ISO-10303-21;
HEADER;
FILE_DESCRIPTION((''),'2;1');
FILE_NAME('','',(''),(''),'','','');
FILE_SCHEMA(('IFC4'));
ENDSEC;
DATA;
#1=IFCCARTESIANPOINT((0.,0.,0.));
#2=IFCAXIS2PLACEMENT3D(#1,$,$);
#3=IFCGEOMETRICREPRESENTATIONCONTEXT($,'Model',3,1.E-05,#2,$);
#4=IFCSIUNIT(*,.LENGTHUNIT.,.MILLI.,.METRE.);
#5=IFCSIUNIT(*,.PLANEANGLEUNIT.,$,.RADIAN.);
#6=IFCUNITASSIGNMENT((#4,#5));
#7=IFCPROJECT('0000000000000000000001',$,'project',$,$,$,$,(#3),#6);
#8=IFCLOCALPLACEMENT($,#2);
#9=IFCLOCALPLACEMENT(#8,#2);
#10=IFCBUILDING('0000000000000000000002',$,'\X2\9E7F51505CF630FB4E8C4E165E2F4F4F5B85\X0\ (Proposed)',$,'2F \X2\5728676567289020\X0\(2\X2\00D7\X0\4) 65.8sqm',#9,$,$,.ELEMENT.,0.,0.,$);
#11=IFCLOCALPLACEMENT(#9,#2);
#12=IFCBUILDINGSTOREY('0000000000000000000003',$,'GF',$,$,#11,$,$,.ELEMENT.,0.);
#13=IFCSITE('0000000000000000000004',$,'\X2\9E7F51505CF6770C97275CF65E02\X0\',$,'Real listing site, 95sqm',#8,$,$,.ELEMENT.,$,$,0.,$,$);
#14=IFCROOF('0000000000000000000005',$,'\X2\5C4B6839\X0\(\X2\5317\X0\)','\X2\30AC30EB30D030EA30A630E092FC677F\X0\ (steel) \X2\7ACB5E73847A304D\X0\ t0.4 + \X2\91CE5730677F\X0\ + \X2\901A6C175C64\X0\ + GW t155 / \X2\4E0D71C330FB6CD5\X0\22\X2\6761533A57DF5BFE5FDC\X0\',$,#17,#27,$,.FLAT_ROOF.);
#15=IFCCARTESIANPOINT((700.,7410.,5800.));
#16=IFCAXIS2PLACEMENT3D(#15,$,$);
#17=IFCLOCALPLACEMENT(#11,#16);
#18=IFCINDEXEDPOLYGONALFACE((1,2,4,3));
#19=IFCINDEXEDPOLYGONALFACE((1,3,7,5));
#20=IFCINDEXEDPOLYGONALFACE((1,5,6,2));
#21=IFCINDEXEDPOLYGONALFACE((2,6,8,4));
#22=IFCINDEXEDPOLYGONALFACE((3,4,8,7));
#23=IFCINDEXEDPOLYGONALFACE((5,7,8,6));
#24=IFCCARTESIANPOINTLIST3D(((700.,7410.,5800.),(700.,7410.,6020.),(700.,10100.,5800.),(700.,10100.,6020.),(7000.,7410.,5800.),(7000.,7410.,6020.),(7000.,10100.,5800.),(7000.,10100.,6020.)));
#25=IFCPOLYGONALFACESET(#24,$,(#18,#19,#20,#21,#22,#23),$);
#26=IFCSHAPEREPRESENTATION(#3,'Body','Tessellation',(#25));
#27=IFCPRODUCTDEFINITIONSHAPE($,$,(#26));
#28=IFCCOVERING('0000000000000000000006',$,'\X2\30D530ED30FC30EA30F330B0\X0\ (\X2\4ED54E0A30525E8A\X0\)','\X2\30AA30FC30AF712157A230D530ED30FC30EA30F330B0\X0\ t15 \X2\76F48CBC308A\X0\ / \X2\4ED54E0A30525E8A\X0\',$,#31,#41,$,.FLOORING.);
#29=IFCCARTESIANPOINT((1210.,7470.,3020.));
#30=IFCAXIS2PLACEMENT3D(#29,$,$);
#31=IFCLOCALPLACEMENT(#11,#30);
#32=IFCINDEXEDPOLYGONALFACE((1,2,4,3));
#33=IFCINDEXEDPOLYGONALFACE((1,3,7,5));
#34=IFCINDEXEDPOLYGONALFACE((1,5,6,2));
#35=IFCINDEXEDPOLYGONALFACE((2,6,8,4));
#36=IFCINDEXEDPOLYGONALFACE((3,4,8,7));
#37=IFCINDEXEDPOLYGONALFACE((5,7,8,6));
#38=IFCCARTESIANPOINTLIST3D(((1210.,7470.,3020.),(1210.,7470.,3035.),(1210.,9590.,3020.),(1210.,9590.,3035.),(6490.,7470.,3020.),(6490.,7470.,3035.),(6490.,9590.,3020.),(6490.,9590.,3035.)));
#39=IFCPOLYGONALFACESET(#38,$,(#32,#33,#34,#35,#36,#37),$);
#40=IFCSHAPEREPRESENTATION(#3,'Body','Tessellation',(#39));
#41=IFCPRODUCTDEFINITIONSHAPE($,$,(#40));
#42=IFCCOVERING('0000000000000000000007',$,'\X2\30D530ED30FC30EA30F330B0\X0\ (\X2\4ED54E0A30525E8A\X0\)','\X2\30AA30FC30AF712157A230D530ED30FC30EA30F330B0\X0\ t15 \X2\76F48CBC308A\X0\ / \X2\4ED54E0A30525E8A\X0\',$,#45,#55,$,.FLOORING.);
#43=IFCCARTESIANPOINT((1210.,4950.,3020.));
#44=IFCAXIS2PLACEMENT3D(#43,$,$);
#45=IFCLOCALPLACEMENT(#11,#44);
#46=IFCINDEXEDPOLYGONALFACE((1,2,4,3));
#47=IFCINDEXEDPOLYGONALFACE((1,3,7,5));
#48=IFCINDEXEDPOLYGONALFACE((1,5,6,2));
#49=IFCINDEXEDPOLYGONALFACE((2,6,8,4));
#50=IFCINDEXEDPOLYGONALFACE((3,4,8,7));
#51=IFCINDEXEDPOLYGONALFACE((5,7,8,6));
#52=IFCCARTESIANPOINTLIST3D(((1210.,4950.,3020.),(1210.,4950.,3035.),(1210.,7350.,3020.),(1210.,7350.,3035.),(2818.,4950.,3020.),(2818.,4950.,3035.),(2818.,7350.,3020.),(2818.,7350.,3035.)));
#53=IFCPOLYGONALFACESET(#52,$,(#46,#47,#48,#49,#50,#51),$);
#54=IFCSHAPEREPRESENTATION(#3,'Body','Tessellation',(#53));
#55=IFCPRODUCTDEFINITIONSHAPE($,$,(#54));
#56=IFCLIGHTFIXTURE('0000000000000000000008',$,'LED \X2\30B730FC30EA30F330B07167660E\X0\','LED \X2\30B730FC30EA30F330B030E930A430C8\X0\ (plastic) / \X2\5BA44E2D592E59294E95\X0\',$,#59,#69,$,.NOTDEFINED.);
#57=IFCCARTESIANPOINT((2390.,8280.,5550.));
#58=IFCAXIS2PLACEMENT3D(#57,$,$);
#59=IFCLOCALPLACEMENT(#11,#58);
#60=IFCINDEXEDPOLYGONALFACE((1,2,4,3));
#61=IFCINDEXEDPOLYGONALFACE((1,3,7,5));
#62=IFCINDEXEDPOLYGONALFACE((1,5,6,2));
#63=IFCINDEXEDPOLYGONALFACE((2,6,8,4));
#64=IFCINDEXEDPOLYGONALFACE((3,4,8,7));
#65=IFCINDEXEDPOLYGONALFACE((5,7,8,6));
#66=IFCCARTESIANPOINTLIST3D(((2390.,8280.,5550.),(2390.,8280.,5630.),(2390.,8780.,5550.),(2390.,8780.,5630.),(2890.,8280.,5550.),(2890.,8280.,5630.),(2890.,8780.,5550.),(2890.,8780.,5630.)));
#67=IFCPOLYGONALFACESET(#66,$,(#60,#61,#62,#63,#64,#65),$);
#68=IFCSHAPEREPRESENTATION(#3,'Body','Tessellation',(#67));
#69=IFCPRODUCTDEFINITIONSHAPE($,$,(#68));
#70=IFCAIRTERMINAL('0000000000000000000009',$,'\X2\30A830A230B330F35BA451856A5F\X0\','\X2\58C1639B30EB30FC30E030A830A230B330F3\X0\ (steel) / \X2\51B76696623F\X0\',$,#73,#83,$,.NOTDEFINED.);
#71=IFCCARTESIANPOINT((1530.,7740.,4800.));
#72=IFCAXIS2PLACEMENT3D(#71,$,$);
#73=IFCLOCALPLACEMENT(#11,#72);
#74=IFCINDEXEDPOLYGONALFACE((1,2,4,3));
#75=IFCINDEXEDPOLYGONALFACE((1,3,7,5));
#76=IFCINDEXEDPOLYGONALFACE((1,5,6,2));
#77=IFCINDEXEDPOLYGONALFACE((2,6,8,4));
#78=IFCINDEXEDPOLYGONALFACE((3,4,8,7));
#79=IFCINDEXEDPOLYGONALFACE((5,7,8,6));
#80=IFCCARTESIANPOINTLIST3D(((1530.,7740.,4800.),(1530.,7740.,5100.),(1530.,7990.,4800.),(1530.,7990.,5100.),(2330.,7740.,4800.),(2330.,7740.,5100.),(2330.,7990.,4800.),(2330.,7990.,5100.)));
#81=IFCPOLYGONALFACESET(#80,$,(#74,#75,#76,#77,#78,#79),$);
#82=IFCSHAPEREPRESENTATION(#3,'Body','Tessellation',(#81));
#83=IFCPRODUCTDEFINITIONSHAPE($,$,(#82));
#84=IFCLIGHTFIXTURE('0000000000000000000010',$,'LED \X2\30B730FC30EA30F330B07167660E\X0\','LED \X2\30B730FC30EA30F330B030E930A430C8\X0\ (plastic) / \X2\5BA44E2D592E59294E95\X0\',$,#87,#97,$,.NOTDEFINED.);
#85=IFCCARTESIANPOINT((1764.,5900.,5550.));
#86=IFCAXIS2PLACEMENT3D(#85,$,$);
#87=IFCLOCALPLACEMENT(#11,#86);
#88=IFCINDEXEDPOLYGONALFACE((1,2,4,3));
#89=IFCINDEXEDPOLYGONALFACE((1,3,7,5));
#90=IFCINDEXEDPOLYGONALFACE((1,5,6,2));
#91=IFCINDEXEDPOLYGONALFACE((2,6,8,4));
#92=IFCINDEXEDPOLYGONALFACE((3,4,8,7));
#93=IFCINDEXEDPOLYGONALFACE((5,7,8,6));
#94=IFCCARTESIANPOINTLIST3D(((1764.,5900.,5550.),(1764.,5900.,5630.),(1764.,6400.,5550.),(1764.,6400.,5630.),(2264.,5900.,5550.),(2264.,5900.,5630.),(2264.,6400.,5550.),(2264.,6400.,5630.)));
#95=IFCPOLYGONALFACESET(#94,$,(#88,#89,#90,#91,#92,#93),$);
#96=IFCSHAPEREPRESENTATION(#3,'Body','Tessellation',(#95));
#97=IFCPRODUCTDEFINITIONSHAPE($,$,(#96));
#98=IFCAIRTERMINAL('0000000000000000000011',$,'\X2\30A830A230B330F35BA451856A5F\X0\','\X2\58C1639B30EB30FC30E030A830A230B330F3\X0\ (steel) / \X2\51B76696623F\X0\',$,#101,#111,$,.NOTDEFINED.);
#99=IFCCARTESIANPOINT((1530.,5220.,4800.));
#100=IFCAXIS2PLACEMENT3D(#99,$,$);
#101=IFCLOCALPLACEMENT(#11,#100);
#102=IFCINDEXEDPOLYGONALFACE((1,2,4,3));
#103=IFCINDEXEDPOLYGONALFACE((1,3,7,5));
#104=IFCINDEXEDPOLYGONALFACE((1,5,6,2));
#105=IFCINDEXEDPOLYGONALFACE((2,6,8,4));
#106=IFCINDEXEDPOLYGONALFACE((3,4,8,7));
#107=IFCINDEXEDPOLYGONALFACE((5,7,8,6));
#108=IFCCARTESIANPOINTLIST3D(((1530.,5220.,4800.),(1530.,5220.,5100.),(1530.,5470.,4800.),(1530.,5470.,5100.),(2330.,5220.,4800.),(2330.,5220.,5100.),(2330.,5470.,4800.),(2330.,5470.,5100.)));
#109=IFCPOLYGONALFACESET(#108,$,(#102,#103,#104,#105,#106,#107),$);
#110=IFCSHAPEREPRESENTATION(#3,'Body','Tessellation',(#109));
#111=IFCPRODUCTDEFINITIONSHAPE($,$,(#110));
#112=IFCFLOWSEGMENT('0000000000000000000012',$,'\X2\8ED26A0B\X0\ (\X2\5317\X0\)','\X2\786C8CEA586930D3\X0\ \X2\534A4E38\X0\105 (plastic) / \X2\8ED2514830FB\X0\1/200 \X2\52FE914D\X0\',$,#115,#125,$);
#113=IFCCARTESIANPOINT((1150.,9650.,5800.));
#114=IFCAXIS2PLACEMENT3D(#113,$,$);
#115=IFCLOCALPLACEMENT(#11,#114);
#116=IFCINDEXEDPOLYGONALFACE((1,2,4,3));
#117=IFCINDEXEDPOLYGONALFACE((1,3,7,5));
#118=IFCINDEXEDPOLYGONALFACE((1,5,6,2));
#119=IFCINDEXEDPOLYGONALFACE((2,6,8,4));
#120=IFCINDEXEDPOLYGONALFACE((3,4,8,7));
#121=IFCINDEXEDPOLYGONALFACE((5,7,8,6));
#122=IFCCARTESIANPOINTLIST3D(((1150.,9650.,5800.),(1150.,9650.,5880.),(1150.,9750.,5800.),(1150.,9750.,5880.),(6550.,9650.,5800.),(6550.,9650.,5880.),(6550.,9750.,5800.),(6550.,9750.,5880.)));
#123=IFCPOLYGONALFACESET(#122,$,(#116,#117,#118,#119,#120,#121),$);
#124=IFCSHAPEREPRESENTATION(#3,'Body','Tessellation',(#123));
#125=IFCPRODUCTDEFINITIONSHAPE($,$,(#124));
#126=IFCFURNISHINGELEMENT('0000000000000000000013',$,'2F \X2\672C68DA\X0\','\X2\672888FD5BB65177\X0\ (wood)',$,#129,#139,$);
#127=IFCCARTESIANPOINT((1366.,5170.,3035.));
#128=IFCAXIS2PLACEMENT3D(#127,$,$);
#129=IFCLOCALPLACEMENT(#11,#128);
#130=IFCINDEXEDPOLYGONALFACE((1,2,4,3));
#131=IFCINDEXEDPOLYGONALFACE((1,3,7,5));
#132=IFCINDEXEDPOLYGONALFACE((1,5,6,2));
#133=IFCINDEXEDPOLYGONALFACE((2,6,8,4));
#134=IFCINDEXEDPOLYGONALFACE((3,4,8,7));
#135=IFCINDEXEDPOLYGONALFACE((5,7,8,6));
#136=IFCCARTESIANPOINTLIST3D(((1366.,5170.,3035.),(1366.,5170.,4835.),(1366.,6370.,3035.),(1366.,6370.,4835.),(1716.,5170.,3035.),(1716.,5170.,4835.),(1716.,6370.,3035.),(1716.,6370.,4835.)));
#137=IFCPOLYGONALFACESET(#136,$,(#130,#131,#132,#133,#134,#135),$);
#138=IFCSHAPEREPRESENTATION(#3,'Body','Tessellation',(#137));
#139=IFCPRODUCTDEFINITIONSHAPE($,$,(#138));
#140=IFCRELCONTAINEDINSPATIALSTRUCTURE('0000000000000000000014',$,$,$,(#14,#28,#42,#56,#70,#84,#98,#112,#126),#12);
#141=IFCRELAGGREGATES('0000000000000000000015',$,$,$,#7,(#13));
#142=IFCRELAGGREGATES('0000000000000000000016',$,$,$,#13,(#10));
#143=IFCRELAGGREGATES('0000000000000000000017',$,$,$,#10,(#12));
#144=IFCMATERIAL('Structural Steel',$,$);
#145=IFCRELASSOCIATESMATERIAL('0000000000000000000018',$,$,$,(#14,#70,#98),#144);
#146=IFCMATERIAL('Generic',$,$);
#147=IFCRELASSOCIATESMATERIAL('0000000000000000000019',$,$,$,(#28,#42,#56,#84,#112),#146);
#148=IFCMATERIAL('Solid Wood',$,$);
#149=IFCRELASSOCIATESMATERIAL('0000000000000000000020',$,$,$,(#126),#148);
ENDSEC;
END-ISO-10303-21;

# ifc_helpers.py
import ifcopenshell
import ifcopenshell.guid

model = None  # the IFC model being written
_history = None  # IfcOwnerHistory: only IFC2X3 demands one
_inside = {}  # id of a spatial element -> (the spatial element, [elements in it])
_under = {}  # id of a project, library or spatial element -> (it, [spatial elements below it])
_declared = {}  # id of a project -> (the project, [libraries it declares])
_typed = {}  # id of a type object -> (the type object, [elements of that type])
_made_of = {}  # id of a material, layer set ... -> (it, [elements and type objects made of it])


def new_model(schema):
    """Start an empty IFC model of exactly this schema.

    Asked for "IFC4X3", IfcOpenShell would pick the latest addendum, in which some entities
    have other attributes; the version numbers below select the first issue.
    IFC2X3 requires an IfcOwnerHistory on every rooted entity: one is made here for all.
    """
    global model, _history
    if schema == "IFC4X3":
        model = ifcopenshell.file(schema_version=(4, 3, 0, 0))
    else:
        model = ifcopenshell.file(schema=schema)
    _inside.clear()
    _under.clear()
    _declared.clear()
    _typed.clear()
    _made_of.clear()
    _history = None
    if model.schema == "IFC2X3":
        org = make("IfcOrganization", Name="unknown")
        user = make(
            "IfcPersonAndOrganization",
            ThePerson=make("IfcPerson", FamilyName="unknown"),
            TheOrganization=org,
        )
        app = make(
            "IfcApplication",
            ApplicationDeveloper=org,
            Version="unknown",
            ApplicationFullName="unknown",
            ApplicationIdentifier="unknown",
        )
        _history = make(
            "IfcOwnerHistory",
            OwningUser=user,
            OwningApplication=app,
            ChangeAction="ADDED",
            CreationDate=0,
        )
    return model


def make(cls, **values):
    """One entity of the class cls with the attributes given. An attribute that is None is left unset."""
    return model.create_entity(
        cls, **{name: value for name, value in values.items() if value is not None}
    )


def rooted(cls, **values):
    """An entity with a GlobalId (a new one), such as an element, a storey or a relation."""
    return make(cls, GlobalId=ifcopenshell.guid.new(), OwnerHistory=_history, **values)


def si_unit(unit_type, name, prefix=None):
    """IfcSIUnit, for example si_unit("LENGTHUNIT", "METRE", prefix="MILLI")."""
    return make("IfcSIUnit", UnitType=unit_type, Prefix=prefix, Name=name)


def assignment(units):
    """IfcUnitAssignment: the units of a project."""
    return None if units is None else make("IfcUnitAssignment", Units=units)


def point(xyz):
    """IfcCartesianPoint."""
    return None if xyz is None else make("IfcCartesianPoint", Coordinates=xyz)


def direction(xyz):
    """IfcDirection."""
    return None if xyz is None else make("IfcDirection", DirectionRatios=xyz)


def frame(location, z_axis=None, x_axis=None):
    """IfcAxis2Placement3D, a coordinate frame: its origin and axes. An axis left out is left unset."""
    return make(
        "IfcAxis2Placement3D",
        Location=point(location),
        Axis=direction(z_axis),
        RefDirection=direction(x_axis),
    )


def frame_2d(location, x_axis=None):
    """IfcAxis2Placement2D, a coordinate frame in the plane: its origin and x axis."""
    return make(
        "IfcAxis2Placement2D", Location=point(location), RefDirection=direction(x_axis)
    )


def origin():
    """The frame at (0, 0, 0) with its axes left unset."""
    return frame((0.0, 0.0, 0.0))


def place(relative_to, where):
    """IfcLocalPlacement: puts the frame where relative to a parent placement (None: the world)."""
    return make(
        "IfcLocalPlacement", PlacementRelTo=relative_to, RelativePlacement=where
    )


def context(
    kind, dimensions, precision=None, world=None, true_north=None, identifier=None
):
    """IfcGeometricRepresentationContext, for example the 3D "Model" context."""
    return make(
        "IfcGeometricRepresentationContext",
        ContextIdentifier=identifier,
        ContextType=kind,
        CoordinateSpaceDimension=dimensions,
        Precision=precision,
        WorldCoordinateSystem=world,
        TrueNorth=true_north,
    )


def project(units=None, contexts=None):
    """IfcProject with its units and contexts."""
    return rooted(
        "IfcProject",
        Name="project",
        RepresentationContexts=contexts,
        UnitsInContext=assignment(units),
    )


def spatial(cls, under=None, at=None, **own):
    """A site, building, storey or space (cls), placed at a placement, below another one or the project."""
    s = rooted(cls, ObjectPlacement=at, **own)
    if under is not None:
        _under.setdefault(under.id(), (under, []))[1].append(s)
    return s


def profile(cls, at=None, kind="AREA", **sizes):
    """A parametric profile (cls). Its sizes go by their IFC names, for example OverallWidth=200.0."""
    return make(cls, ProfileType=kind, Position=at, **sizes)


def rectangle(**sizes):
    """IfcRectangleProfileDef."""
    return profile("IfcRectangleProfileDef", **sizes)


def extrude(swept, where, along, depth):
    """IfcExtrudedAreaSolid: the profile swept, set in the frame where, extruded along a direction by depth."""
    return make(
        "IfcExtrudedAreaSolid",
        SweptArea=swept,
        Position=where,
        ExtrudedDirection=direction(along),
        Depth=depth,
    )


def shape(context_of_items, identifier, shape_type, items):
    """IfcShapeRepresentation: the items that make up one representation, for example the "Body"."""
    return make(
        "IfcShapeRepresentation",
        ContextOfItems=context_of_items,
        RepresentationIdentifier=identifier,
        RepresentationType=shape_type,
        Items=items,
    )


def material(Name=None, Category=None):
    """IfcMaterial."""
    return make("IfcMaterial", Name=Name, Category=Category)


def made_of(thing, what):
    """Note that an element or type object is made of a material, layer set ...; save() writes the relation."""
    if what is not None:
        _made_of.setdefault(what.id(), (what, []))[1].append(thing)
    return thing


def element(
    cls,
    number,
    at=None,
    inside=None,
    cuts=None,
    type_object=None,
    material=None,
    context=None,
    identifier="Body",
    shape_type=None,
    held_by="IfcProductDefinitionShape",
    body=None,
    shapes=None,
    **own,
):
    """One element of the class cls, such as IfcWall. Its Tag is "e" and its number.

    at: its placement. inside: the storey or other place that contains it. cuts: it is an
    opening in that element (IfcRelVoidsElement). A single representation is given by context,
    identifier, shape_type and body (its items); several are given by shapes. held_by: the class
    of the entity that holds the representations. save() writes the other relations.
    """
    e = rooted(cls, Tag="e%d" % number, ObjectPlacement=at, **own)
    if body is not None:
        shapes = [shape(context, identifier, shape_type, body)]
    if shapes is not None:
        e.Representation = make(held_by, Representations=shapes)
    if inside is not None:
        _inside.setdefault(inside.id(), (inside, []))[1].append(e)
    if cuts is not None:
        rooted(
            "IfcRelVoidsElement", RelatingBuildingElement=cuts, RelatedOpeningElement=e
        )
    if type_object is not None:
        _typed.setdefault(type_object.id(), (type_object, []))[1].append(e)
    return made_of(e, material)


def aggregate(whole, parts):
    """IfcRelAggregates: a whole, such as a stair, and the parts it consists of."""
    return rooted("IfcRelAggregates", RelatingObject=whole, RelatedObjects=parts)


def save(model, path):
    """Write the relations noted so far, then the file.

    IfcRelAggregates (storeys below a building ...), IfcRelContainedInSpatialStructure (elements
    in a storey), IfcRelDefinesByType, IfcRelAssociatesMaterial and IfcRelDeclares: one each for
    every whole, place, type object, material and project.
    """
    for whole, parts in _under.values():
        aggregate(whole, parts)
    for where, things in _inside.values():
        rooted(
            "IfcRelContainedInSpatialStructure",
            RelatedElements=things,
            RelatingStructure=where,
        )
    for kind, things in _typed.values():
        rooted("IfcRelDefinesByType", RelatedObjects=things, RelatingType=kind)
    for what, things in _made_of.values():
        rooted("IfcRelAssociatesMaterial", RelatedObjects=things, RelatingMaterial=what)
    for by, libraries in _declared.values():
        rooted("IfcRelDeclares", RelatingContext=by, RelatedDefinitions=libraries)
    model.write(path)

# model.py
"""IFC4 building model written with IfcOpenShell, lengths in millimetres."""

from ifc_helpers import new_model, si_unit, frame, frame_2d, origin, place, context, project, spatial, rectangle, extrude, material, element, save


model = new_model("IFC4")

# Units and contexts
model_context = context("Model", 3, precision=1e-05, world=origin())
ifc_project = project(units=[si_unit("LENGTHUNIT", "METRE", prefix="MILLI"), si_unit("PLANEANGLEUNIT", "RADIAN")], contexts=[model_context])

# Site, building, storey
site_placement = place(None, origin())
site = spatial("IfcSite", under=ifc_project, at=site_placement, Name="鹿児島県霧島市", ObjectType="Real listing site, 95sqm", CompositionType="ELEMENT", RefElevation=0.0)
building_placement = place(site_placement, origin())
building = spatial("IfcBuilding", under=site, at=building_placement, Name="鹿児島・二世帯住宅 (Proposed)", ObjectType="2F 在来木造(2×4) 65.8sqm", CompositionType="ELEMENT", ElevationOfRefHeight=0.0, ElevationOfTerrain=0.0)
storey_placement = place(building_placement, origin())
storey = spatial("IfcBuildingStorey", under=building, at=storey_placement, Name="GF", CompositionType="ELEMENT", Elevation=0.0)

# Shared definitions
ifc_material_1 = material(Name="Solid Wood")

# Roof
ifc_material_2 = material(Name="Structural Steel")
for number, where, name in (
    (1, (700.0, 7410.0, 5800.0), "屋根(北)"),
):
    element("IfcRoof", number, at=place(storey_placement, frame(where)), inside=storey, material=ifc_material_2, Name=name, Description="ガルバリウム鋼板 (steel) 立平葺き t0.4 + 野地板 + 通気層 + GW t155 / 不燃・法22条区域対応", PredefinedType="FLAT_ROOF", context=model_context, shape_type="SweptSolid", body=[
        extrude(rectangle(XDim=6300.0, YDim=2690.0, at=frame_2d((3150.0, 1345.0))), frame((700.0, 7410.0, 5800.0)), (0.0, 0.0, 1.0), 220.0),
    ])

# Coverings
ifc_material_3 = material(Name="Generic")
covering_1_placement = place(storey_placement, frame((1210.0, 7470.0, 3020.0)))
element("IfcCovering", 2, at=covering_1_placement, inside=storey, material=ifc_material_3, Name="フローリング (仕上げ床)", Description="オーク無垢フローリング t15 直貼り / 仕上げ床", PredefinedType="FLOORING", context=model_context, shape_type="SweptSolid", body=[
    extrude(rectangle(XDim=5280.0, YDim=2120.0, at=frame_2d((2640.0, 1060.0))), frame((1210.0, 7470.0, 3020.0)), (0.0, 0.0, 1.0), 15.0),
])
covering_2_placement = place(storey_placement, frame((1210.0, 4950.0, 3020.0)))
element("IfcCovering", 3, at=covering_2_placement, inside=storey, material=ifc_material_3, Name="フローリング (仕上げ床)", Description="オーク無垢フローリング t15 直貼り / 仕上げ床", PredefinedType="FLOORING", context=model_context, shape_type="SweptSolid", body=[
    extrude(rectangle(XDim=1608.0, YDim=2400.0, at=frame_2d((804.0, 1200.0))), frame((1210.0, 4950.0, 3020.0)), (0.0, 0.0, 1.0), 15.0),
])

# Light fixture
light_fixture_1_placement = place(storey_placement, frame((2390.0, 8280.0, 5550.0)))
element("IfcLightFixture", 4, at=light_fixture_1_placement, inside=storey, material=ifc_material_3, Name="LED シーリング照明", Description="LED シーリングライト (plastic) / 室中央天井", PredefinedType="NOTDEFINED", context=model_context, shape_type="SweptSolid", body=[
    extrude(rectangle(XDim=500.0, YDim=500.0, at=frame_2d((250.0, 250.0))), frame((2390.0, 8280.0, 5550.0)), (0.0, 0.0, 1.0), 80.0),
])

# Air terminal
air_terminal_1_placement = place(storey_placement, frame((1530.0, 7740.0, 4800.0)))
element("IfcAirTerminal", 5, at=air_terminal_1_placement, inside=storey, material=ifc_material_2, Name="エアコン室内機", Description="壁掛ルームエアコン (steel) / 冷暖房", PredefinedType="NOTDEFINED", context=model_context, shape_type="SweptSolid", body=[
    extrude(rectangle(XDim=800.0, YDim=250.0, at=frame_2d((400.0, 125.0))), frame((1530.0, 7740.0, 4800.0)), (0.0, 0.0, 1.0), 300.0),
])

# Light fixture
light_fixture_2_placement = place(storey_placement, frame((1764.0, 5900.0, 5550.0)))
element("IfcLightFixture", 6, at=light_fixture_2_placement, inside=storey, material=ifc_material_3, Name="LED シーリング照明", Description="LED シーリングライト (plastic) / 室中央天井", PredefinedType="NOTDEFINED", context=model_context, shape_type="SweptSolid", body=[
    extrude(rectangle(XDim=500.0, YDim=500.0, at=frame_2d((250.0, 250.0))), frame((1764.0, 5900.0, 5550.0)), (0.0, 0.0, 1.0), 80.0),
])

# Air terminal
air_terminal_2_placement = place(storey_placement, frame((1530.0, 5220.0, 4800.0)))
element("IfcAirTerminal", 7, at=air_terminal_2_placement, inside=storey, material=ifc_material_2, Name="エアコン室内機", Description="壁掛ルームエアコン (steel) / 冷暖房", PredefinedType="NOTDEFINED", context=model_context, shape_type="SweptSolid", body=[
    extrude(rectangle(XDim=800.0, YDim=250.0, at=frame_2d((400.0, 125.0))), frame((1530.0, 5220.0, 4800.0)), (0.0, 0.0, 1.0), 300.0),
])

# Flow segment
flow_segment_placement = place(storey_placement, frame((1150.0, 9650.0, 5800.0)))
element("IfcFlowSegment", 8, at=flow_segment_placement, inside=storey, material=ifc_material_3, Name="軒樋 (北)", Description="硬質塩ビ 半丸105 (plastic) / 軒先・1/200 勾配", context=model_context, shape_type="SweptSolid", body=[
    extrude(rectangle(XDim=5400.0, YDim=100.0, at=frame_2d((2700.0, 50.0))), frame((1150.0, 9650.0, 5800.0)), (0.0, 0.0, 1.0), 80.0),
])

# Furnishing element
furnishing_placement = place(storey_placement, frame((1366.0, 5170.0, 3035.0)))
element("IfcFurnishingElement", 9, at=furnishing_placement, inside=storey, material=ifc_material_1, Name="2F 本棚", Description="木製家具 (wood)", context=model_context, shape_type="SweptSolid", body=[
    extrude(rectangle(XDim=350.0, YDim=1200.0, at=frame_2d((175.0, 600.0))), frame((1366.0, 5170.0, 3035.0)), (0.0, 0.0, 1.0), 1800.0),
])

save(model, "model.ifc")
